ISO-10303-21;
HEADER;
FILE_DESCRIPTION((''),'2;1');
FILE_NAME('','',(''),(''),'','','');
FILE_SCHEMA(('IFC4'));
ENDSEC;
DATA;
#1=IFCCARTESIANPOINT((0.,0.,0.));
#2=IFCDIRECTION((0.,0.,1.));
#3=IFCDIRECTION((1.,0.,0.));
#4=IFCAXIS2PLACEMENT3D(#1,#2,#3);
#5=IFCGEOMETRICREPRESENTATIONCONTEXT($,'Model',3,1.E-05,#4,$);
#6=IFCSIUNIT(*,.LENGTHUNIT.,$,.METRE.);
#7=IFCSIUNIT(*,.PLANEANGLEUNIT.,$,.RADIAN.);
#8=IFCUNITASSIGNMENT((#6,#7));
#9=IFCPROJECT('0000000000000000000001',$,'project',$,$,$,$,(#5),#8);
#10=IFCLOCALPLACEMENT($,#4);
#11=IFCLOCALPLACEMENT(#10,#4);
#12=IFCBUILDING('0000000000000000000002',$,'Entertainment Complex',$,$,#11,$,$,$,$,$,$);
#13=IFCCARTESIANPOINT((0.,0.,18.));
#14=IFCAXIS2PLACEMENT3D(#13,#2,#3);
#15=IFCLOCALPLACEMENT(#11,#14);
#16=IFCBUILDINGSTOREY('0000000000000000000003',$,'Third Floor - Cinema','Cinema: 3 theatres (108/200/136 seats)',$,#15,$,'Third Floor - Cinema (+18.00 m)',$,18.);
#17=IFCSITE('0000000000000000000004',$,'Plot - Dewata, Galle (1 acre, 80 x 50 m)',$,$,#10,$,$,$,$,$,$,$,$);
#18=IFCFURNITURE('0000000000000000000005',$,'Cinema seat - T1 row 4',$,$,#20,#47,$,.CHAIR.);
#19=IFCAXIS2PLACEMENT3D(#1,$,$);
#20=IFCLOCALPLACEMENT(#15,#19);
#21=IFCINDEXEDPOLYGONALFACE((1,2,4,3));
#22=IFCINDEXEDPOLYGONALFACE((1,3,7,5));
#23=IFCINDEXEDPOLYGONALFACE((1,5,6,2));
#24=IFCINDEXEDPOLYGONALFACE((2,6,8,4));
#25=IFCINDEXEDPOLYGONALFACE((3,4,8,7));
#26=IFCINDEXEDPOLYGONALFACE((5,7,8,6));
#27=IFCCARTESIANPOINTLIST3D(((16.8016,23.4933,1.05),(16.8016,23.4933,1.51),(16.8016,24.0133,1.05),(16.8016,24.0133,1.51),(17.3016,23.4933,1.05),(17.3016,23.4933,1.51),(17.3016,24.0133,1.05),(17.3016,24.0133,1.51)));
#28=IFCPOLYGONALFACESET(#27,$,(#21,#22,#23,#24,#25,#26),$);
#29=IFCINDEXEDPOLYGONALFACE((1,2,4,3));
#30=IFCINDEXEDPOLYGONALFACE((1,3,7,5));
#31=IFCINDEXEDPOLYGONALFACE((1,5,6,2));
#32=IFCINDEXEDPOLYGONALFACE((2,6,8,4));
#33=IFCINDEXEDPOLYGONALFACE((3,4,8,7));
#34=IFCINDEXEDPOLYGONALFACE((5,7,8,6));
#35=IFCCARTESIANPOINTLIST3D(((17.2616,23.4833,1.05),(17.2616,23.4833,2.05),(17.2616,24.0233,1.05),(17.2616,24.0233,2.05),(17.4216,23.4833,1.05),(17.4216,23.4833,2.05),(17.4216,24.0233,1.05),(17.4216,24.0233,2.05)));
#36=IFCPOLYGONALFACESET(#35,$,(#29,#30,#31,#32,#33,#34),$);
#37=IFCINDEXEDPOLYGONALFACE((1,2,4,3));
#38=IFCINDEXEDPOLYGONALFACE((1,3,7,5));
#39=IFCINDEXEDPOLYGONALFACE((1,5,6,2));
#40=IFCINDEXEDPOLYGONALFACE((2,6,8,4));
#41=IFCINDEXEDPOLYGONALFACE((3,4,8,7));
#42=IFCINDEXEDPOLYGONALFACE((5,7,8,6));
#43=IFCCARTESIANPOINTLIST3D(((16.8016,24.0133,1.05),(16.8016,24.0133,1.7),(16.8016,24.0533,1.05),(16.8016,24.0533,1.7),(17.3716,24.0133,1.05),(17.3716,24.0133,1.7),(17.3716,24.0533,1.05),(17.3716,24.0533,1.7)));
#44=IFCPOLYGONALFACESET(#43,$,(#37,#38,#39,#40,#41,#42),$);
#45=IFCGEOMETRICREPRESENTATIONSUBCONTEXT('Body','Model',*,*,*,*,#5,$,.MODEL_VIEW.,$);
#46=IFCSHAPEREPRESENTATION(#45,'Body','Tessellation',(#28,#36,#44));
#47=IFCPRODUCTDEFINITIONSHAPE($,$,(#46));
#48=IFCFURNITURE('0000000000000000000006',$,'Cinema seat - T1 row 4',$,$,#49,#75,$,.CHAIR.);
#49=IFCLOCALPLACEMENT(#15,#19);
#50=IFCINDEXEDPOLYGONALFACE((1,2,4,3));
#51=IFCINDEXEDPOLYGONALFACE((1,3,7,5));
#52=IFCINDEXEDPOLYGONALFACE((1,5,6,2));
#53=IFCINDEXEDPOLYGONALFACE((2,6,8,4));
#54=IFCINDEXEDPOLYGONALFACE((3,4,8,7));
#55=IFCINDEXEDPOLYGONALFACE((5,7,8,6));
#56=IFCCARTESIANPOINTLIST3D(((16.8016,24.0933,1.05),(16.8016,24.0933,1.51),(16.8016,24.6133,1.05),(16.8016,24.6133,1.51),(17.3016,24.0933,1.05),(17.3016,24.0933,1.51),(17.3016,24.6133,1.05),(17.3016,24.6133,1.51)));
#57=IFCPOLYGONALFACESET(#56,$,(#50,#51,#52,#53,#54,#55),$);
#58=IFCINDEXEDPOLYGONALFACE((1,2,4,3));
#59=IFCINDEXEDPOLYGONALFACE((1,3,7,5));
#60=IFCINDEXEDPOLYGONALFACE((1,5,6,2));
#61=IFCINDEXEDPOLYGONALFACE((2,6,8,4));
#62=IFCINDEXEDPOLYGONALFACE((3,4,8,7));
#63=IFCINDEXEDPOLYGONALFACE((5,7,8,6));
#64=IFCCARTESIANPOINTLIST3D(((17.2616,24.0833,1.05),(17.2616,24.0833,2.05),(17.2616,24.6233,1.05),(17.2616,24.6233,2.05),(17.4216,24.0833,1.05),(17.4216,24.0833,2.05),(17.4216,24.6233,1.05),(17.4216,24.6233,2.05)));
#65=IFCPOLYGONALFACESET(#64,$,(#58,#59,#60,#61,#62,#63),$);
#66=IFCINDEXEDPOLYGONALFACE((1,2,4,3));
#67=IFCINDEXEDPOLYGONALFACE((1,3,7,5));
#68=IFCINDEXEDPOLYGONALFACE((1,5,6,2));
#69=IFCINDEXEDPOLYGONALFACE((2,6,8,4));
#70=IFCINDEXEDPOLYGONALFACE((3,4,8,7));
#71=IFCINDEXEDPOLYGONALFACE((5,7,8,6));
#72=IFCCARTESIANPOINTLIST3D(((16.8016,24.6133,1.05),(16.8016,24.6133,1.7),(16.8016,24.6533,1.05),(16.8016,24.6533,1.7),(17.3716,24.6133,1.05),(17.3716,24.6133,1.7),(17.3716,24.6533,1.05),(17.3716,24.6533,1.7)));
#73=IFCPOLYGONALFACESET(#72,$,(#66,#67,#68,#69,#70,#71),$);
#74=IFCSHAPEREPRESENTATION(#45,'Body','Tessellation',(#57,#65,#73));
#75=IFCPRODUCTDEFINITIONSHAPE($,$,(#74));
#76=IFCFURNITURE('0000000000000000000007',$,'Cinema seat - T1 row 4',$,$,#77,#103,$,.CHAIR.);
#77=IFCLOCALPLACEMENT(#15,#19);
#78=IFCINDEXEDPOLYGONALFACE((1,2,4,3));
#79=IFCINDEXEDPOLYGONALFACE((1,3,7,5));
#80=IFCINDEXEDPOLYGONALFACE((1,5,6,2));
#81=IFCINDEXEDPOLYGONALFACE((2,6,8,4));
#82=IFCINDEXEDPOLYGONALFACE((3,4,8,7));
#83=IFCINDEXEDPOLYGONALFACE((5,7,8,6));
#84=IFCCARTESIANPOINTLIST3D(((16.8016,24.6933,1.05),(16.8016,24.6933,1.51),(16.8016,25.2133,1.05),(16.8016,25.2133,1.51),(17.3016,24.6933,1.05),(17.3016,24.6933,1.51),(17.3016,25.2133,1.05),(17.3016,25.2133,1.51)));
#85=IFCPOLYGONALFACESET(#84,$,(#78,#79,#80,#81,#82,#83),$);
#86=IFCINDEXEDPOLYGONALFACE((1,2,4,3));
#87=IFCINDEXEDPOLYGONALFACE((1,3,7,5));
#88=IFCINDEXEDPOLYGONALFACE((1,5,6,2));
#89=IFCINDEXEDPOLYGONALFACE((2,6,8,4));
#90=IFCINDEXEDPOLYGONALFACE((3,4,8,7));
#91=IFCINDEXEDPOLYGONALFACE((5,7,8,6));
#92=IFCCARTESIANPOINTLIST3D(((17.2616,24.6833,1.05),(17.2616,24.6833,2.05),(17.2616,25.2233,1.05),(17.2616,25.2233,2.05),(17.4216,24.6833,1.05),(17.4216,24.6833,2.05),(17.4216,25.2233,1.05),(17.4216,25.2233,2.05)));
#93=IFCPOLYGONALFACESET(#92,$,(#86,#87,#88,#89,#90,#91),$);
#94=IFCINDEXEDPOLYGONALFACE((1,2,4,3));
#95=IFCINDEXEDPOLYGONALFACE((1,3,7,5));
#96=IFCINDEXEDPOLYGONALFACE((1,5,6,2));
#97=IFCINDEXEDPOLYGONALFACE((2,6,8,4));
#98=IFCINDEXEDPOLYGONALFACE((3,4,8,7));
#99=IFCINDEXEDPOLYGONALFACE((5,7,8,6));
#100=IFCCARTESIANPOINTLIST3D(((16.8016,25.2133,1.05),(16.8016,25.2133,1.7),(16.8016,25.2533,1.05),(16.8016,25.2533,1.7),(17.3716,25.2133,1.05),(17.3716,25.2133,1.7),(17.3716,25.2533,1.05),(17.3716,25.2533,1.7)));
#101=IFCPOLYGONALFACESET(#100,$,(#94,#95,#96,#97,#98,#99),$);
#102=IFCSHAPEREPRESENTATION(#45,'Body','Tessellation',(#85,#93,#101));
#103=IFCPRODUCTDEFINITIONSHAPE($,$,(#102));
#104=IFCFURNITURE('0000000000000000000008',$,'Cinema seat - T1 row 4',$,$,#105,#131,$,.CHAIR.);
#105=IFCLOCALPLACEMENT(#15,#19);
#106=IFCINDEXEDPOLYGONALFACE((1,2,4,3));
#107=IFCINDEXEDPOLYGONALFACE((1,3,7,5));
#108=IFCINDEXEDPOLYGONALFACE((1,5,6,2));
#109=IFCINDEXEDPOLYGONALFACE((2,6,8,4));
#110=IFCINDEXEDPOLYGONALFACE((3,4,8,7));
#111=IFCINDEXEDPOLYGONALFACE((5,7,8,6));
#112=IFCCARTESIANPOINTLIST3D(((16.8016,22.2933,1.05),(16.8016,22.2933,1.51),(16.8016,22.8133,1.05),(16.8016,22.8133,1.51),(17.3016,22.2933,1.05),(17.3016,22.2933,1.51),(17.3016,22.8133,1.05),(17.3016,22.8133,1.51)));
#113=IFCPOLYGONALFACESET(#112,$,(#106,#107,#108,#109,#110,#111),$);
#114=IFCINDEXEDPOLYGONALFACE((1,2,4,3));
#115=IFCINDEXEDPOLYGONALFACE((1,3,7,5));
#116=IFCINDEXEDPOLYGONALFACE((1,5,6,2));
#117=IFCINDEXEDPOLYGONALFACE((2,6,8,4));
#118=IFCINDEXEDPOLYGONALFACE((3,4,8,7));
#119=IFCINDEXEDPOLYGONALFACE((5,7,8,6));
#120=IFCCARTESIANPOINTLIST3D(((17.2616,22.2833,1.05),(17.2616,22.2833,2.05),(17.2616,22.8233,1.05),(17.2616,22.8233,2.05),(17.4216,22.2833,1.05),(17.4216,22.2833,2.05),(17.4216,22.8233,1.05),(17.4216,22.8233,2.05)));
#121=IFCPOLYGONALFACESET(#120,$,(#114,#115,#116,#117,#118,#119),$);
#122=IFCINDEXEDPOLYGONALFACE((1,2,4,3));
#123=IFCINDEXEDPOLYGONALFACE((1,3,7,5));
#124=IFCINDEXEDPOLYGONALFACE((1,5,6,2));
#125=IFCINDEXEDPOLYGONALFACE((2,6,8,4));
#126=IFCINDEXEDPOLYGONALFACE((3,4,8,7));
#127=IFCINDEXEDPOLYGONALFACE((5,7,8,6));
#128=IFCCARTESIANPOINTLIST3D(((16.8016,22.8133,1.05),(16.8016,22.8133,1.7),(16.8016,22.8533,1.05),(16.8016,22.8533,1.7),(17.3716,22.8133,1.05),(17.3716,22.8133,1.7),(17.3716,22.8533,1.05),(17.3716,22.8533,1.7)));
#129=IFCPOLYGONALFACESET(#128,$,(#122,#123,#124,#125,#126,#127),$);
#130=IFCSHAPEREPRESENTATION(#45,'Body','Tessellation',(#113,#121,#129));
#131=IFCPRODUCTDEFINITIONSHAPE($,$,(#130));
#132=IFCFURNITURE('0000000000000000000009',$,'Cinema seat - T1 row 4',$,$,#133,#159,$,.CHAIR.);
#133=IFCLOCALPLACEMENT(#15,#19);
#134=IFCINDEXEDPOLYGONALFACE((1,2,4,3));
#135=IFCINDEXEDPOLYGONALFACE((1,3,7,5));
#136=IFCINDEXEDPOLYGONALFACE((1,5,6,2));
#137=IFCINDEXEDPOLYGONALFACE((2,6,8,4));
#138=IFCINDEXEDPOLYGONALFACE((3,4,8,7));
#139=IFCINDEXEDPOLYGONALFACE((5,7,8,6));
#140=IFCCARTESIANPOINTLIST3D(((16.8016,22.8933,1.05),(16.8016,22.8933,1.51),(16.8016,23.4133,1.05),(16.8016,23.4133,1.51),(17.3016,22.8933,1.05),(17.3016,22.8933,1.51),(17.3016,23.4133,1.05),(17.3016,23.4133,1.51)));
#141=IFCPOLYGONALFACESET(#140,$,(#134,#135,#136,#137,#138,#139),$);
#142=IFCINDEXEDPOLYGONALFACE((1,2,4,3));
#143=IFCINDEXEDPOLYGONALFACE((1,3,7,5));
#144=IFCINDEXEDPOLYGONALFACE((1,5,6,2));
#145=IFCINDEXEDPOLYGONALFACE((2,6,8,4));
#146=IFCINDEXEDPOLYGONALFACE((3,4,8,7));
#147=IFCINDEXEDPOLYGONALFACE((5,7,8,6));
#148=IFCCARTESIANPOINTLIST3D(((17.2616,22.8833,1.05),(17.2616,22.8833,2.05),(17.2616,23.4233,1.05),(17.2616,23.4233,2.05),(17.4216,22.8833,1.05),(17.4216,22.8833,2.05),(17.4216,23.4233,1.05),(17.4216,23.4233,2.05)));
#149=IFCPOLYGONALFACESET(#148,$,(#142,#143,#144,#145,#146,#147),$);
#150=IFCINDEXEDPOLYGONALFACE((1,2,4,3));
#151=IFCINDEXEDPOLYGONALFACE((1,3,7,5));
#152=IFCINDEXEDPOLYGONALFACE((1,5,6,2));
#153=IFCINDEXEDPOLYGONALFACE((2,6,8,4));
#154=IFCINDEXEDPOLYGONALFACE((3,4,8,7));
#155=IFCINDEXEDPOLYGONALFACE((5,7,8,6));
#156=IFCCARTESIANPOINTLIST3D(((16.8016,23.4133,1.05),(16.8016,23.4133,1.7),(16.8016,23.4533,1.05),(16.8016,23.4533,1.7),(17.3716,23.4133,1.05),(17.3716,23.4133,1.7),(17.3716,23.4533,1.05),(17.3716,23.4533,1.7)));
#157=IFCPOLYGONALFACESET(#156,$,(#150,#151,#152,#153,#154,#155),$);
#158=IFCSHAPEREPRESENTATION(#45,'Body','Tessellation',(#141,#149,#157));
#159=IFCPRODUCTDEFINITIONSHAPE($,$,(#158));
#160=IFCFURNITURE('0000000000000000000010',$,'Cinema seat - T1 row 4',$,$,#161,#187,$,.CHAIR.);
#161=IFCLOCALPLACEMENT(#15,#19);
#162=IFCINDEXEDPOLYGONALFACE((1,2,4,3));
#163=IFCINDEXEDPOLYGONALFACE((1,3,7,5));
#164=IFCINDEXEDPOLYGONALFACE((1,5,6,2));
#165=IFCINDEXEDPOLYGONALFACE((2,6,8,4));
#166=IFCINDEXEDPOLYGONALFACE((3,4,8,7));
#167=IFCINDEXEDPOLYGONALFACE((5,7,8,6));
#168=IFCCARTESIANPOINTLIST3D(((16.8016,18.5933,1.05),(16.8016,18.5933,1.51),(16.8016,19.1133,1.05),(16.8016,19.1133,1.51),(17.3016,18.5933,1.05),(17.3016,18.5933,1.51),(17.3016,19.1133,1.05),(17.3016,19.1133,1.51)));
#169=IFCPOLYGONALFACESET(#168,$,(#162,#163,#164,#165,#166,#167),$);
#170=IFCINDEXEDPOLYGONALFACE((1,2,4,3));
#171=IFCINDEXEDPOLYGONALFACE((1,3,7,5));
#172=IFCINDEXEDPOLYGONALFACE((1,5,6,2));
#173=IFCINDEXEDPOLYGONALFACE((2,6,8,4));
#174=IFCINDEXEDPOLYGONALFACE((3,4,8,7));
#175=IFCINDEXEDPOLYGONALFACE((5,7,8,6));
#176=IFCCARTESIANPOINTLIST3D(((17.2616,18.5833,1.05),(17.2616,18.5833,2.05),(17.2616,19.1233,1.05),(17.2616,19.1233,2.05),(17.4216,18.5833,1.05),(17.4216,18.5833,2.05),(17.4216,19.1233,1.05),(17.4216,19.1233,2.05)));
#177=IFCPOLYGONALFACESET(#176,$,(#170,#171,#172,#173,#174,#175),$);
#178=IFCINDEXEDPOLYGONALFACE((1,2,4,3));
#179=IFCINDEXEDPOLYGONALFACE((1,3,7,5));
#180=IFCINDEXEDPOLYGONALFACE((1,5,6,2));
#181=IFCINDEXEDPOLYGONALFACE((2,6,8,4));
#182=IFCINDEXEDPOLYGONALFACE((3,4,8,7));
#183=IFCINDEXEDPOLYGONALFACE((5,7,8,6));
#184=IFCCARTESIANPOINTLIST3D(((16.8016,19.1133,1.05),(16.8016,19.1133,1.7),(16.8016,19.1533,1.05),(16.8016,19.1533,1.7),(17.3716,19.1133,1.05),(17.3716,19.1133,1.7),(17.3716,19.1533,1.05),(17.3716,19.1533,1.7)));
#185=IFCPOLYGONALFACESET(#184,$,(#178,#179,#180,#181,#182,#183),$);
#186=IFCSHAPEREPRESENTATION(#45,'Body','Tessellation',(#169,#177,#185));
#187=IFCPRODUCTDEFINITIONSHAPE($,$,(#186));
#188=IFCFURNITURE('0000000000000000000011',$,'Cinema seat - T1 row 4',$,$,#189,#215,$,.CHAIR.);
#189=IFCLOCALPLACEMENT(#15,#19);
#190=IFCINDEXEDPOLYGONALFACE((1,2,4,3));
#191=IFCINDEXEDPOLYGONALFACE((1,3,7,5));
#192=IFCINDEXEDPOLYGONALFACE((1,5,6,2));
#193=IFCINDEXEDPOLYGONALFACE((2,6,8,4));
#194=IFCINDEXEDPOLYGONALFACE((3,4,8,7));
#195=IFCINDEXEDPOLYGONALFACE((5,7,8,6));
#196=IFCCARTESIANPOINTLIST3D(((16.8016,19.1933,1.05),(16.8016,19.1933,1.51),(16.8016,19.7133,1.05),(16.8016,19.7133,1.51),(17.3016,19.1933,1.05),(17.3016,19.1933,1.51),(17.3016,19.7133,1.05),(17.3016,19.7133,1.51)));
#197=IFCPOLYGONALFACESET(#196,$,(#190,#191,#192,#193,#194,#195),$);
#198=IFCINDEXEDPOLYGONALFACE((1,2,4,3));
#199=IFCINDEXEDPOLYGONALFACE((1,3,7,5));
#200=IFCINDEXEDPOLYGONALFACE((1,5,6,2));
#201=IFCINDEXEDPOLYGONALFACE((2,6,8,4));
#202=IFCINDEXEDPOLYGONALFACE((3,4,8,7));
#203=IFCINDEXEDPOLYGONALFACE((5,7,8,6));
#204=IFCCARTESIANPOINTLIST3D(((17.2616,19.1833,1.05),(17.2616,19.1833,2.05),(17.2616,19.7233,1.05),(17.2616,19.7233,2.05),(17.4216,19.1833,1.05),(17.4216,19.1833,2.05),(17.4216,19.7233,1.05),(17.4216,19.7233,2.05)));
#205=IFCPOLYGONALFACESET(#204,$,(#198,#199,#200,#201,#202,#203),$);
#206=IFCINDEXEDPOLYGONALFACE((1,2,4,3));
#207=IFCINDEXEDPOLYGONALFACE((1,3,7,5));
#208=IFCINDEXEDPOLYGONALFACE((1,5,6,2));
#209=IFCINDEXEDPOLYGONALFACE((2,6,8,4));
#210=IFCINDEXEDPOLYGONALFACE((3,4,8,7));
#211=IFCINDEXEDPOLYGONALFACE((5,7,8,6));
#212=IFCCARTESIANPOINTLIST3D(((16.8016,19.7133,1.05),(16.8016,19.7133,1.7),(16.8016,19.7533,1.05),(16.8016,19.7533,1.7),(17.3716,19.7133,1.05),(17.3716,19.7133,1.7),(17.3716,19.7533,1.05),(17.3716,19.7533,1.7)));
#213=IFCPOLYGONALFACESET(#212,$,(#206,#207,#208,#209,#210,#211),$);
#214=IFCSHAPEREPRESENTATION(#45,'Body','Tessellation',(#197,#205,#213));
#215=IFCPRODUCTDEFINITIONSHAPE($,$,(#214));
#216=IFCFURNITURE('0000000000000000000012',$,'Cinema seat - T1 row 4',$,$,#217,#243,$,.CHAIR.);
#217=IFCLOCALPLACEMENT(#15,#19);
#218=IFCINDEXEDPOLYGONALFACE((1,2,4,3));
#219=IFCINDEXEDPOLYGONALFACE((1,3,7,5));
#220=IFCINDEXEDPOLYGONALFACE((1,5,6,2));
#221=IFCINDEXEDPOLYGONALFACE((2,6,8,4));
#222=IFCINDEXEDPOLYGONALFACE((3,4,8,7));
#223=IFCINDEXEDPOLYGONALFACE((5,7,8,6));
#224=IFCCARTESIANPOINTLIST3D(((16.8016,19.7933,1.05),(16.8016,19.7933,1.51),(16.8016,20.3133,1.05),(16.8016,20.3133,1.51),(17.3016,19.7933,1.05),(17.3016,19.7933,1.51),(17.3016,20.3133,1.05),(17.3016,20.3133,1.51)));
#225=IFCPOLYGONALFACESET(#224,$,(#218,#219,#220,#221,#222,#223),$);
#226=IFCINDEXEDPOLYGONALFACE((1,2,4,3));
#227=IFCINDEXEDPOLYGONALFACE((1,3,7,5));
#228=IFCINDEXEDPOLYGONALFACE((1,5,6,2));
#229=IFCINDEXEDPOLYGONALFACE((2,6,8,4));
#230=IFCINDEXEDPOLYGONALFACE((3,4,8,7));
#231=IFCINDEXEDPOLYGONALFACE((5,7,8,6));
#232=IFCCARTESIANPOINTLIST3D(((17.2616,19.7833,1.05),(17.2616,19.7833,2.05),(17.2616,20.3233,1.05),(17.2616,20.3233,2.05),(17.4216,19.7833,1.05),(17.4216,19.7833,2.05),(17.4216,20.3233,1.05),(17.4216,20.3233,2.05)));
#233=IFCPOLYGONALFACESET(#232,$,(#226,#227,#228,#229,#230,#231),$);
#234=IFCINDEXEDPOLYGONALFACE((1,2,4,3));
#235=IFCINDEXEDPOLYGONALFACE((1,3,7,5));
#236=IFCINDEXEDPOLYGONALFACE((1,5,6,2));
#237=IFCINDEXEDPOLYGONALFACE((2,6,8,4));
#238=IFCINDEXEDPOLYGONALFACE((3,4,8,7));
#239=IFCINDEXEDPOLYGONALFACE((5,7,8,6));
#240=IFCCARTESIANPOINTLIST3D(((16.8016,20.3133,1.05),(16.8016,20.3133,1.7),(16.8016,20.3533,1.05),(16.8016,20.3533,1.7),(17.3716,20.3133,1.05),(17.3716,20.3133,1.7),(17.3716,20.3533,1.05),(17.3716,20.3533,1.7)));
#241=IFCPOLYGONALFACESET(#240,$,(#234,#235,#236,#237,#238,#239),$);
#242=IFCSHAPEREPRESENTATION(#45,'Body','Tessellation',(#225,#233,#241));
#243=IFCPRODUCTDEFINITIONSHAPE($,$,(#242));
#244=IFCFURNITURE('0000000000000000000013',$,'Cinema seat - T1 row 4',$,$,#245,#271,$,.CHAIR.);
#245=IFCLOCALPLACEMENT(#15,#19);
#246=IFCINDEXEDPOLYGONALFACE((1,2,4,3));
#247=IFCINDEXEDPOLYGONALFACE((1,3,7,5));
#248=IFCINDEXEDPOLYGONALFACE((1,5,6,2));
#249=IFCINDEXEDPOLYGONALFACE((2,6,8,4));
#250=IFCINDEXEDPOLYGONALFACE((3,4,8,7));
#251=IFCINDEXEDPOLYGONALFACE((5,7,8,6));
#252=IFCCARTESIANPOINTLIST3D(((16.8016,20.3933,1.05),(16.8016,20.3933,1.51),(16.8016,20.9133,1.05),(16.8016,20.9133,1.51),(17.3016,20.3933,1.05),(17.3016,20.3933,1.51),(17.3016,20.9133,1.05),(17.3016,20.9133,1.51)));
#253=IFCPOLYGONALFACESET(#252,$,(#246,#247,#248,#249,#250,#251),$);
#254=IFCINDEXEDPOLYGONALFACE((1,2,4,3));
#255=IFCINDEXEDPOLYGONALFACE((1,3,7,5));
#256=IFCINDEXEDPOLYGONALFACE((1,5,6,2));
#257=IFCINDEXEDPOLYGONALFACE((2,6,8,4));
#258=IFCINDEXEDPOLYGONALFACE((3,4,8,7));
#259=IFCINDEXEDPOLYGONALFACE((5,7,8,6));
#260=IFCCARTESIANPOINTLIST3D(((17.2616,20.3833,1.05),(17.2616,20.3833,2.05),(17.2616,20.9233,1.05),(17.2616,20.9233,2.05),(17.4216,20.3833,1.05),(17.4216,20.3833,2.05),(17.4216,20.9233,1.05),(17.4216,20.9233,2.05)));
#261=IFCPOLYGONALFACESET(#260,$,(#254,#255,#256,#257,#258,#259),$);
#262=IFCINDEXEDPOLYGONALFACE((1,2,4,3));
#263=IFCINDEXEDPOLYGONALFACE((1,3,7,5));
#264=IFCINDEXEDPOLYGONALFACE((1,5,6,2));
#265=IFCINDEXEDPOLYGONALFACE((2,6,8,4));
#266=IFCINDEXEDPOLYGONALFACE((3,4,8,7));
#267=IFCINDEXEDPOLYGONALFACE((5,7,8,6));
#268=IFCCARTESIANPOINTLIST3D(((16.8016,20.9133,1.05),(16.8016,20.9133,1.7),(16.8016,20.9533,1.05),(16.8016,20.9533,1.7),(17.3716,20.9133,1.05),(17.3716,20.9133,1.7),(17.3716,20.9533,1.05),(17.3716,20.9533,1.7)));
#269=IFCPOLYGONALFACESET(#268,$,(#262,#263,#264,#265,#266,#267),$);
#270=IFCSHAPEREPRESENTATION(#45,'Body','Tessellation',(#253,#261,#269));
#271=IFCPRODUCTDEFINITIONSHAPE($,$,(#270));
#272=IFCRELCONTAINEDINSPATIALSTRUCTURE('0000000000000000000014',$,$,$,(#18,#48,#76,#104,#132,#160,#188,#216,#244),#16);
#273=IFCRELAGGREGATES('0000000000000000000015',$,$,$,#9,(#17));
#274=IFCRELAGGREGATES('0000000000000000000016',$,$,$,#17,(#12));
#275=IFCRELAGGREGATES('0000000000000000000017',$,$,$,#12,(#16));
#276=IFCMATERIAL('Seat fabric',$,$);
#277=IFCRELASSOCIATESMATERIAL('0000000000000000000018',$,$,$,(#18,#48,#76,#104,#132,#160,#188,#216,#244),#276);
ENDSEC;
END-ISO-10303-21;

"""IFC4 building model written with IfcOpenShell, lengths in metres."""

from ifc_helpers import new_model, si_unit, frame, origin_with_axes, place, context, subcontext, project, spatial, polyline, outline, extrude, material, element, save


model = new_model("IFC4")

# Units and contexts
model_context = context("Model", 3, precision=1e-05, world=origin_with_axes())
body_context = subcontext(model_context, "Body", "Model", "MODEL_VIEW")
ifc_project = project(units=[si_unit("LENGTHUNIT", "METRE"), si_unit("PLANEANGLEUNIT", "RADIAN")], contexts=[model_context])

# Site, building, storey
site_placement = place(None, origin_with_axes())
site = spatial("IfcSite", under=ifc_project, at=site_placement, Name="Plot - Dewata, Galle (1 acre, 80 x 50 m)")
building_placement = place(site_placement, origin_with_axes())
building = spatial("IfcBuilding", under=site, at=building_placement, Name="Entertainment Complex")
storey_placement = place(building_placement, frame((0.0, 0.0, 18.0), z_axis=(0.0, 0.0, 1.0), x_axis=(1.0, 0.0, 0.0)))
storey = spatial("IfcBuildingStorey", under=building, at=storey_placement, Name="Third Floor - Cinema", Description="Cinema: 3 theatres (108/200/136 seats)", LongName="Third Floor - Cinema (+18.00 m)", Elevation=18.0)

# Furniture
ifc_material = material(Name="Seat fabric")
for number, where, z_axis, x_axis, name in (
    (1, (17.4216, 23.7533, 1.05), (0.0, 0.0, 1.0), (1.0, 0.0, 0.0), "Cinema seat - T1 row 4"),
    (2, (17.4216, 24.3533, 1.05), (0.0, 0.0, 1.0), (1.0, 0.0, 0.0), "Cinema seat - T1 row 4"),
    (3, (17.4216, 24.9533, 1.05), (0.0, 0.0, 1.0), (1.0, 0.0, 0.0), "Cinema seat - T1 row 4"),
    (4, (17.4216, 22.5533, 1.05), (0.0, 0.0, 1.0), (1.0, 0.0, 0.0), "Cinema seat - T1 row 4"),
    (5, (17.4216, 23.1533, 1.05), (0.0, 0.0, 1.0), (1.0, 0.0, 0.0), "Cinema seat - T1 row 4"),
    (6, (17.4216, 18.8533, 1.05), (0.0, 0.0, 1.0), (1.0, 0.0, 0.0), "Cinema seat - T1 row 4"),
    (7, (17.4216, 19.4533, 1.05), (0.0, 0.0, 1.0), (1.0, 0.0, 0.0), "Cinema seat - T1 row 4"),
    (8, (17.4216, 20.0533, 1.05), (0.0, 0.0, 1.0), (1.0, 0.0, 0.0), "Cinema seat - T1 row 4"),
    (9, (17.4216, 20.6533, 1.05), (0.0, 0.0, 1.0), (1.0, 0.0, 0.0), "Cinema seat - T1 row 4"),
):
    element("IfcFurniture", number, at=place(storey_placement, frame(where, z_axis=z_axis, x_axis=x_axis)), inside=storey, material=ifc_material, Name=name, PredefinedType="CHAIR", context=body_context, shape_type="SweptSolid", body=[
        extrude(outline(polyline([(-0.62, -0.26), (-0.12, -0.26), (-0.12, 0.26), (-0.62, 0.26), (-0.62, -0.26)])), origin_with_axes(), (0.0, 0.0, 1.0), 0.46),
        extrude(outline(polyline([(-0.16, -0.27), (0.0, -0.27), (0.0, 0.27), (-0.16, 0.27), (-0.16, -0.27)])), origin_with_axes(), (0.0, 0.0, 1.0), 1.0),
        extrude(outline(polyline([(-0.62, 0.26), (-0.05, 0.26), (-0.05, 0.3), (-0.62, 0.3), (-0.62, 0.26)])), origin_with_axes(), (0.0, 0.0, 1.0), 0.65),
    ])

save(model, "model.ifc")
